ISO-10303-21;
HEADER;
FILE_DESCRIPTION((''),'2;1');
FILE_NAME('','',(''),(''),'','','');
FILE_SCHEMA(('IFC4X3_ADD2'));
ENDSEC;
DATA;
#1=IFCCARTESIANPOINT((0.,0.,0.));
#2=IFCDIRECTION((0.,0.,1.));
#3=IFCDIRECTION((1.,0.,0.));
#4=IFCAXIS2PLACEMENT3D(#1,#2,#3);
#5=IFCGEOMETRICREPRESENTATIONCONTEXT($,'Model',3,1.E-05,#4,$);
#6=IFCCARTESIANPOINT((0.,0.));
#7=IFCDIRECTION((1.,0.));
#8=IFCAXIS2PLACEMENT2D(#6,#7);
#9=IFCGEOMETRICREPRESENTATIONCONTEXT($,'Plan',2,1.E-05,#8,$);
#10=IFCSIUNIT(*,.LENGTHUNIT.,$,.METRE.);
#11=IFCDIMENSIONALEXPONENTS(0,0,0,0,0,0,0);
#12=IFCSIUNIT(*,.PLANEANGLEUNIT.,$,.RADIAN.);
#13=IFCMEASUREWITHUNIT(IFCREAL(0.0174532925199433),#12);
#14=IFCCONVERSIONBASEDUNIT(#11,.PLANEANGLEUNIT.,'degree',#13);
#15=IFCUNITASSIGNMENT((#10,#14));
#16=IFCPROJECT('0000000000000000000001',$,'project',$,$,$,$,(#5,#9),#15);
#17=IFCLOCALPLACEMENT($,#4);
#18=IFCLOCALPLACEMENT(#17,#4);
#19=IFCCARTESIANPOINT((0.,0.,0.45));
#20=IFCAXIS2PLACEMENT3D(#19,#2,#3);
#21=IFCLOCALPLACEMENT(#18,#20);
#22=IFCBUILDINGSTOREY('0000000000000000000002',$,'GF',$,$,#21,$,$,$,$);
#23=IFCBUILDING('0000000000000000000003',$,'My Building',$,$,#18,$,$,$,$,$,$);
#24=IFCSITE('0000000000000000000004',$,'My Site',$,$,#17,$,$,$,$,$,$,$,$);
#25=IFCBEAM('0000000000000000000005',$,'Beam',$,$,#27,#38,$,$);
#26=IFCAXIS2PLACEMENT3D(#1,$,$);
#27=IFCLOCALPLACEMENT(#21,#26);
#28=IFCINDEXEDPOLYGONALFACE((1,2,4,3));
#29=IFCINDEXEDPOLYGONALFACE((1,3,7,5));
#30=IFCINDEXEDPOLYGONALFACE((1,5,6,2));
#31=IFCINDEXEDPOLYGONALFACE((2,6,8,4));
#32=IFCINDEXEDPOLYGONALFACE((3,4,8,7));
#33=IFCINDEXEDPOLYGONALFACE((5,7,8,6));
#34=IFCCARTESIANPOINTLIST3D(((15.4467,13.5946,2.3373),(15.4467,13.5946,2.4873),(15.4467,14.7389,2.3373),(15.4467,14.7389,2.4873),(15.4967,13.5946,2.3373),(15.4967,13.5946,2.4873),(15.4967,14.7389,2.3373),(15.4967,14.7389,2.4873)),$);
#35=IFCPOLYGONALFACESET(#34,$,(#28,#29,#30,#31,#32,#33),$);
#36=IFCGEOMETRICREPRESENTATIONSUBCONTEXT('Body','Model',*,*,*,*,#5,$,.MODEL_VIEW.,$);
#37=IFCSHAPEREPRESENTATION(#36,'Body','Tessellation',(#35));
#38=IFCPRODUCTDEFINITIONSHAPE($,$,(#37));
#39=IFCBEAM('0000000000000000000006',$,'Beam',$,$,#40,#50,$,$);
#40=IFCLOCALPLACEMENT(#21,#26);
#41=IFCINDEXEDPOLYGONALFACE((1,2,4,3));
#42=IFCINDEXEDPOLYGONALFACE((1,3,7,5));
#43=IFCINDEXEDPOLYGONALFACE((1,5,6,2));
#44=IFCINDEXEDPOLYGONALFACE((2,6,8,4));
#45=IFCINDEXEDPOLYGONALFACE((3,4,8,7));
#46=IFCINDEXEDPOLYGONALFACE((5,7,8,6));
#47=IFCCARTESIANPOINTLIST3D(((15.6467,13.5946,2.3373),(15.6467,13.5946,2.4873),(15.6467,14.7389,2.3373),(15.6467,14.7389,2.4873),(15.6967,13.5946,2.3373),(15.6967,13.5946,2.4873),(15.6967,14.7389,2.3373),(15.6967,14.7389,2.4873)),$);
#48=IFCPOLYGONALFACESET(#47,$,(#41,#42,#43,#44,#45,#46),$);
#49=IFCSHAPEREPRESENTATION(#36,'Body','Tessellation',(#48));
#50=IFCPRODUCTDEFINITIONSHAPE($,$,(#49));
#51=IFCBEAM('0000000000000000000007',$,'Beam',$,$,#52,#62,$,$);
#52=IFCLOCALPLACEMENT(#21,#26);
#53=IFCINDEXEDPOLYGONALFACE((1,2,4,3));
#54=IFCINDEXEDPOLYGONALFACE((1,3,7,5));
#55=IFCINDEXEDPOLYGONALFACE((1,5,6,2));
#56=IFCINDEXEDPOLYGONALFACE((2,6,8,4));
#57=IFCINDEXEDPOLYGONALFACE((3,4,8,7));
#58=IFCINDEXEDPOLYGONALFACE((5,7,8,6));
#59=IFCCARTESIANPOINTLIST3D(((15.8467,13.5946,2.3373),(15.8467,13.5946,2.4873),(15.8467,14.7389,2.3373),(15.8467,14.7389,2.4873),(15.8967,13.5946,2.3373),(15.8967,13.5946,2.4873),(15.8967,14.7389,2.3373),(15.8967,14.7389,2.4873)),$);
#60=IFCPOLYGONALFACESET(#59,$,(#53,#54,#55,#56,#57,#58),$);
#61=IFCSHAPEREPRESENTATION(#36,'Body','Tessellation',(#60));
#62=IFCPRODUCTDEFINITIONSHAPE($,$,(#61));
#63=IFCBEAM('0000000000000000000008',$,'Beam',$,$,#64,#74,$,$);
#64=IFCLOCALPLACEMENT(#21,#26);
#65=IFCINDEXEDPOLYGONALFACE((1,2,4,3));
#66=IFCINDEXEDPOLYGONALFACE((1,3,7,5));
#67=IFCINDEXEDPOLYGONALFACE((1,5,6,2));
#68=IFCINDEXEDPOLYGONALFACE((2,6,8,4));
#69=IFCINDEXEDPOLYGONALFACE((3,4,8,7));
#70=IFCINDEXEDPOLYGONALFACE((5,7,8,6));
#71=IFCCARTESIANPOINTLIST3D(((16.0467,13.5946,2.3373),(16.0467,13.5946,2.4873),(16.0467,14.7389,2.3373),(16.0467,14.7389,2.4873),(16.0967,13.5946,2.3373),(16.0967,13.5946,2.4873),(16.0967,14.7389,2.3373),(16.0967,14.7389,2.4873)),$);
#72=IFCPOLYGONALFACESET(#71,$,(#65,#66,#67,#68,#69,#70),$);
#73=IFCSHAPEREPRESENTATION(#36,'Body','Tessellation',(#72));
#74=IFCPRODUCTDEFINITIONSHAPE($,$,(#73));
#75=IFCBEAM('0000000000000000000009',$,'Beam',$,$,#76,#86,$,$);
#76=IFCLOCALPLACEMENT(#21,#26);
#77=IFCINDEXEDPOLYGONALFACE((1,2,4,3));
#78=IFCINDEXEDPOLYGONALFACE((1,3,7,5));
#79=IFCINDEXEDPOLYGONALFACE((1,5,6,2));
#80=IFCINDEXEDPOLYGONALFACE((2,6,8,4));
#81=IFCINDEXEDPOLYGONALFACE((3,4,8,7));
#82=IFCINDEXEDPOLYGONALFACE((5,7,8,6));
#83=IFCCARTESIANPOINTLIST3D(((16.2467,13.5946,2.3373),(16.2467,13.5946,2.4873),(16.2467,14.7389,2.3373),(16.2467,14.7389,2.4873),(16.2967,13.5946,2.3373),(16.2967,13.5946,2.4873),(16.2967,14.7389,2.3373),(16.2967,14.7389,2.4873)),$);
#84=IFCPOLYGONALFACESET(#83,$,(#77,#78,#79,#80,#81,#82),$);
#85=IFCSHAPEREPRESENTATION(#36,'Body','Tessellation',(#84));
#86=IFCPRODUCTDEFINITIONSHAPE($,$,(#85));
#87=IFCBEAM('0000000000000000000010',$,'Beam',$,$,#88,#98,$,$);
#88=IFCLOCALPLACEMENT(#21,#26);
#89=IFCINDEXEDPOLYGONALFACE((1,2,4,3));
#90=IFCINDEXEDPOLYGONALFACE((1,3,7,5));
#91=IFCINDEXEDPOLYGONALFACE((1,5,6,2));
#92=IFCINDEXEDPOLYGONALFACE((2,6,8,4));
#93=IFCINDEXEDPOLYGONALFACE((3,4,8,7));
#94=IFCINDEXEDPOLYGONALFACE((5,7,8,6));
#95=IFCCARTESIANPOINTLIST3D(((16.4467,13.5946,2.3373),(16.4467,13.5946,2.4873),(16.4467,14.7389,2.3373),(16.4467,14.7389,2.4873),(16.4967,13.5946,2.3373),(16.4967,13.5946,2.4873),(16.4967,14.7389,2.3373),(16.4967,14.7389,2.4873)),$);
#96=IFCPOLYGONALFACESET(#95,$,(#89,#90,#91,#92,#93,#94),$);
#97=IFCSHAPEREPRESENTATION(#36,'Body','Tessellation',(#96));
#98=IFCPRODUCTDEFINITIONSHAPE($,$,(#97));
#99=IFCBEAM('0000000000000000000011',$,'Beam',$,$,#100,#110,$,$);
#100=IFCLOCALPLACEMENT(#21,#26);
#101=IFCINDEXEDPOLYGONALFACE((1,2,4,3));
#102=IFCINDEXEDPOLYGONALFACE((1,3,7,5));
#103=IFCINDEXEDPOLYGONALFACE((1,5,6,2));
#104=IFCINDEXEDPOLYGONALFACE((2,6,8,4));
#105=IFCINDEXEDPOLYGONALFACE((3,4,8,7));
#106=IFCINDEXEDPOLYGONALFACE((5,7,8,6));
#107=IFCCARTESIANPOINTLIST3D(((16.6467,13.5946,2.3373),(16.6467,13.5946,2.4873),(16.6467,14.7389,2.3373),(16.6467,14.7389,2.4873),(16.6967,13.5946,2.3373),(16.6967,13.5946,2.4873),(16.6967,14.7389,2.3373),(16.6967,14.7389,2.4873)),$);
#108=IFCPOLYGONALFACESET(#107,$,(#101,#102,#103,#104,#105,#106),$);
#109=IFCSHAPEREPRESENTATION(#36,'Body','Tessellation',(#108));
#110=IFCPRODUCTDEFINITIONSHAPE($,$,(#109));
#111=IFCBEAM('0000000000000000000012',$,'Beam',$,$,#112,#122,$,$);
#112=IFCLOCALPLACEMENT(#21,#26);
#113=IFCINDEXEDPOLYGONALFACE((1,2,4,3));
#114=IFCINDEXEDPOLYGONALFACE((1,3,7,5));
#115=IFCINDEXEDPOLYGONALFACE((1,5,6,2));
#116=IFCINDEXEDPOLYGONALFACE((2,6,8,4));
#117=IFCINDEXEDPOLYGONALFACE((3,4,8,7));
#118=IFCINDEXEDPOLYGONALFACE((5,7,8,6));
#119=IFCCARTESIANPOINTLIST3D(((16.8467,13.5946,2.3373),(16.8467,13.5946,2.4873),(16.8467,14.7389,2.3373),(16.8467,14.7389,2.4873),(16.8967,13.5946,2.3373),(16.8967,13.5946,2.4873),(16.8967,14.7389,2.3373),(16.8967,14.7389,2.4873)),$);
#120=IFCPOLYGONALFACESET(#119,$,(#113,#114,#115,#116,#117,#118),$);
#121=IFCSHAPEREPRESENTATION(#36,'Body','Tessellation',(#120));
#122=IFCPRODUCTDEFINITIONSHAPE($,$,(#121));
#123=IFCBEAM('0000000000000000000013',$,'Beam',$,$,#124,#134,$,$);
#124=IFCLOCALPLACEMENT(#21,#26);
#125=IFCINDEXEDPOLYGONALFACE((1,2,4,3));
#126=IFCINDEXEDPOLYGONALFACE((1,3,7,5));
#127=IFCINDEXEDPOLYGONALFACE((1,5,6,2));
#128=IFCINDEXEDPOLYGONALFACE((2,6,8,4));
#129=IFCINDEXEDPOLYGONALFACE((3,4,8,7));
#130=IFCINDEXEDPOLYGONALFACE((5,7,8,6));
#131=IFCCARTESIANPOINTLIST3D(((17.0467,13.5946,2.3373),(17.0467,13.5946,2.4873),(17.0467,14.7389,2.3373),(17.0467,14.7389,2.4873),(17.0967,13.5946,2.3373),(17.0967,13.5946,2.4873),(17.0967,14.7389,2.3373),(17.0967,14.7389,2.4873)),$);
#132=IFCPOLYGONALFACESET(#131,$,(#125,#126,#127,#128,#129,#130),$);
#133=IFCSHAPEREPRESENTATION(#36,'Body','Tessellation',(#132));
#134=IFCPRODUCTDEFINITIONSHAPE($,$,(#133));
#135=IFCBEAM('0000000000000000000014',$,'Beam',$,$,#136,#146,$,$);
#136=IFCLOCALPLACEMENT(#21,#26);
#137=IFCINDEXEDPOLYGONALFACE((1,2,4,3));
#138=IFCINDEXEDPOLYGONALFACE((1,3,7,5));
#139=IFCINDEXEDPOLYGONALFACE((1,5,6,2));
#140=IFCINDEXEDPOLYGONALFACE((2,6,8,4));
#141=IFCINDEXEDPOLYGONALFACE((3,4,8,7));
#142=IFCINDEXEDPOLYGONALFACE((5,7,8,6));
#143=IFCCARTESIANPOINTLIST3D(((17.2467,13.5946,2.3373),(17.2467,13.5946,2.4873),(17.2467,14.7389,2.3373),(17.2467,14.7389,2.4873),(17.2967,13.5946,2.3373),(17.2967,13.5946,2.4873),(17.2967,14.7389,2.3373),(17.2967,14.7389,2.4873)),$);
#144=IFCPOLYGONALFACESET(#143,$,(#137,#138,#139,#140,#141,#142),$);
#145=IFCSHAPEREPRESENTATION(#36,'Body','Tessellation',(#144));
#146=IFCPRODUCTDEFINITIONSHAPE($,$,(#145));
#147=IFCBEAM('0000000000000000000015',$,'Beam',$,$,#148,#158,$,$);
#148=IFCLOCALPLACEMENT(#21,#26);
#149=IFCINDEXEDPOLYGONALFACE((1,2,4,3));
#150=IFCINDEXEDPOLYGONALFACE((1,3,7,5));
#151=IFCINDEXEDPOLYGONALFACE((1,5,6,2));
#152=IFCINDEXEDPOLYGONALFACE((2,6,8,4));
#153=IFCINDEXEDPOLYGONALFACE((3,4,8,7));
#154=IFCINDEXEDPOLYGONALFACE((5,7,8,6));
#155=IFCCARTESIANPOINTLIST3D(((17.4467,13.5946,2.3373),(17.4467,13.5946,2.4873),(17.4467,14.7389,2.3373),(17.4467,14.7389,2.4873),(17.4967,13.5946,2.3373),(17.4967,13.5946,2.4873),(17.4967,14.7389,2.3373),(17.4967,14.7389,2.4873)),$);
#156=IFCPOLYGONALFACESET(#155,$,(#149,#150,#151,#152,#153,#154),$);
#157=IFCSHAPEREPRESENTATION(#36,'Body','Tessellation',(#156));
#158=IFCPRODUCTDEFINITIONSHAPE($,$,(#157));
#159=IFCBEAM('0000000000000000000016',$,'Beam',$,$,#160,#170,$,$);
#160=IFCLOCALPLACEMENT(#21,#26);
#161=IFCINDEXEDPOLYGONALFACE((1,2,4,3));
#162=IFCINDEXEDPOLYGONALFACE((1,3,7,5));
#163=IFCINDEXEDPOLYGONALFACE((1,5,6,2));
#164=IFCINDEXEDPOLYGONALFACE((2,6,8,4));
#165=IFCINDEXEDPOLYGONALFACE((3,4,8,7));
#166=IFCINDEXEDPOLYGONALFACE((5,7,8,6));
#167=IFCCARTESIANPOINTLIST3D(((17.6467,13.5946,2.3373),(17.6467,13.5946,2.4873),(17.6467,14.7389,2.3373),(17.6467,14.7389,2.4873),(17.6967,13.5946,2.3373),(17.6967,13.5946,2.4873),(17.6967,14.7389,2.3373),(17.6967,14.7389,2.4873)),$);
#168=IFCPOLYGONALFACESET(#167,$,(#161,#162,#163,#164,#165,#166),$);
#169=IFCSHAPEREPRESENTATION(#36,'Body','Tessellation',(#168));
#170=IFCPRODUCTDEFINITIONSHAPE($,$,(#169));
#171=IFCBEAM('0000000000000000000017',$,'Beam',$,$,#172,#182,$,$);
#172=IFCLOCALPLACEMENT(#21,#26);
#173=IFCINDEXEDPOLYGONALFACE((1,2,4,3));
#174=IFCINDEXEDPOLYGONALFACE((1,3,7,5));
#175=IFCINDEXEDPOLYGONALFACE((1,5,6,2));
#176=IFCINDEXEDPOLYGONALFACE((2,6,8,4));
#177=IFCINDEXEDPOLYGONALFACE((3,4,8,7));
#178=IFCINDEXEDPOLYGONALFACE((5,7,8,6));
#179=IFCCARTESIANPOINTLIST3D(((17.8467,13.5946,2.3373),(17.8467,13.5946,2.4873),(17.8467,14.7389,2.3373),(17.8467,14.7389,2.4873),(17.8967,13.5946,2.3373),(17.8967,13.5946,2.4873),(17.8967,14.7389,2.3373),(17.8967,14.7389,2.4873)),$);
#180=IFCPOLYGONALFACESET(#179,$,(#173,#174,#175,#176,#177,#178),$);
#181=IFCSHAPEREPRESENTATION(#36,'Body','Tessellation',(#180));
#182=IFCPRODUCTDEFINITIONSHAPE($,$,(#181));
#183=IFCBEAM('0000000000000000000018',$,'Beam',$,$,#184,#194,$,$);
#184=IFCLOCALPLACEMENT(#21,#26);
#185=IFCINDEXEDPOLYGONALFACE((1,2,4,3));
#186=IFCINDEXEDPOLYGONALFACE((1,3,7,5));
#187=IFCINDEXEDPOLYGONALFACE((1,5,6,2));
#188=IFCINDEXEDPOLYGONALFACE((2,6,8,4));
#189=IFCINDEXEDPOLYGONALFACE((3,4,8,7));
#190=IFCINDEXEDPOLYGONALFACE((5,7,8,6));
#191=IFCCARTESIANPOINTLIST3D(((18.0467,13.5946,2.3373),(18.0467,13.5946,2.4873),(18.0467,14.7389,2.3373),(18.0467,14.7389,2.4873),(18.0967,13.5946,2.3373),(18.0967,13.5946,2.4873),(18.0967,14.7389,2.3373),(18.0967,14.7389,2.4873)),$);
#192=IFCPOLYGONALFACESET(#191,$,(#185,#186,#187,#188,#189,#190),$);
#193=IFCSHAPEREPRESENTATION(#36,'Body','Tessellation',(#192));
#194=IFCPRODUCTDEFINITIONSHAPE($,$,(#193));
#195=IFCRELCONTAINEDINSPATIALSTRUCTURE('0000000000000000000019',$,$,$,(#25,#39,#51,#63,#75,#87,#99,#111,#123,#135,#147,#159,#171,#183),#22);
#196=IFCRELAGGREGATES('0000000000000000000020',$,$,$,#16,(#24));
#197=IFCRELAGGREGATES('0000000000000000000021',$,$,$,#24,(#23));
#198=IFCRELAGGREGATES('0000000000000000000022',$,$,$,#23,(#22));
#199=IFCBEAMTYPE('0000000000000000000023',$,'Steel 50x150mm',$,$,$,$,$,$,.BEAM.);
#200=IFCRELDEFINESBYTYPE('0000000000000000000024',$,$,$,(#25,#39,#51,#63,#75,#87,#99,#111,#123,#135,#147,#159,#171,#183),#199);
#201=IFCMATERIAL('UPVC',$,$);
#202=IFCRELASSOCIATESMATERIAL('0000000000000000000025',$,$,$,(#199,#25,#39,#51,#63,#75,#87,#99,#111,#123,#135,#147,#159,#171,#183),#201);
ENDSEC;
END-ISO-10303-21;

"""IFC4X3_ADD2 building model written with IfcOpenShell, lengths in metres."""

from ifc_helpers import new_model, entity, si_unit, converted_unit, frame, origin_with_axes, origin_2d_with_axis, place, context, subcontext, project, spatial, rectangle, extrude, material, material_profile, profile_set, profile_usage, type_object, element, save


model = new_model("IFC4X3_ADD2")

# Units and contexts
model_context = context("Model", 3, precision=1e-05, world=origin_with_axes())
plan_context = context("Plan", 2, precision=1e-05, world=origin_2d_with_axis())
body_context = subcontext(model_context, "Body", "Model", "MODEL_VIEW")
ifc_project = project(units=[si_unit("LENGTHUNIT", "METRE"), converted_unit("PLANEANGLEUNIT", "degree", entity("IfcReal", 0.0174532925199433), si_unit("PLANEANGLEUNIT", "RADIAN"), dimensions=[0, 0, 0, 0, 0, 0, 0])], contexts=[model_context, plan_context])

# Site, building, storey
site_placement = place(None, origin_with_axes())
site = spatial("IfcSite", under=ifc_project, at=site_placement, Name="My Site")
building_placement = place(site_placement, origin_with_axes())
building = spatial("IfcBuilding", under=site, at=building_placement, Name="My Building")
storey_placement = place(building_placement, frame((0.0, 0.0, 0.45), z_axis=(0.0, 0.0, 1.0), x_axis=(1.0, 0.0, 0.0)))
storey = spatial("IfcBuildingStorey", under=building, at=storey_placement, Name="GF")

# Beams
ifc_material = material(Name="UPVC")
ifc_material_profile = material_profile(ifc_material, rectangle(XDim=0.05, YDim=0.15))
ifc_profile_set = profile_set([ifc_material_profile])
ifc_profile_usage_1 = profile_usage(ifc_profile_set)
beam_type = type_object("IfcBeamType", Name="Steel 50x150mm", PredefinedType="BEAM", material=ifc_profile_set)
beam_1_placement = place(storey_placement, frame((15.4717, 14.7389, 2.4123), z_axis=(0.0, -1.0, 0.0), x_axis=(1.0, 0.0, 0.0)))
element("IfcBeam", 1, at=beam_1_placement, inside=storey, type_object=beam_type, material=ifc_profile_usage_1, Name="Beam", context=body_context, shape_type="SweptSolid", body=[
    extrude(rectangle(XDim=0.05, YDim=0.15), origin_with_axes(), (0.0, 0.0, 1.0), 1.1444),
])
ifc_profile_usage_2 = profile_usage(ifc_profile_set)
beam_2_placement = place(storey_placement, frame((15.6717, 14.7389, 2.4123), z_axis=(0.0, -1.0, 0.0), x_axis=(1.0, 0.0, 0.0)))
element("IfcBeam", 2, at=beam_2_placement, inside=storey, type_object=beam_type, material=ifc_profile_usage_2, Name="Beam", context=body_context, shape_type="SweptSolid", body=[
    extrude(rectangle(XDim=0.05, YDim=0.15), origin_with_axes(), (0.0, 0.0, 1.0), 1.1444),
])
ifc_profile_usage_3 = profile_usage(ifc_profile_set)
beam_3_placement = place(storey_placement, frame((15.8717, 14.7389, 2.4123), z_axis=(0.0, -1.0, 0.0), x_axis=(1.0, 0.0, 0.0)))
element("IfcBeam", 3, at=beam_3_placement, inside=storey, type_object=beam_type, material=ifc_profile_usage_3, Name="Beam", context=body_context, shape_type="SweptSolid", body=[
    extrude(rectangle(XDim=0.05, YDim=0.15), origin_with_axes(), (0.0, 0.0, 1.0), 1.1444),
])
ifc_profile_usage_4 = profile_usage(ifc_profile_set)
beam_4_placement = place(storey_placement, frame((16.0717, 14.7389, 2.4123), z_axis=(0.0, -1.0, 0.0), x_axis=(1.0, 0.0, 0.0)))
element("IfcBeam", 4, at=beam_4_placement, inside=storey, type_object=beam_type, material=ifc_profile_usage_4, Name="Beam", context=body_context, shape_type="SweptSolid", body=[
    extrude(rectangle(XDim=0.05, YDim=0.15), origin_with_axes(), (0.0, 0.0, 1.0), 1.1444),
])
ifc_profile_usage_5 = profile_usage(ifc_profile_set)
beam_5_placement = place(storey_placement, frame((16.2717, 14.7389, 2.4123), z_axis=(0.0, -1.0, 0.0), x_axis=(1.0, 0.0, 0.0)))
element("IfcBeam", 5, at=beam_5_placement, inside=storey, type_object=beam_type, material=ifc_profile_usage_5, Name="Beam", context=body_context, shape_type="SweptSolid", body=[
    extrude(rectangle(XDim=0.05, YDim=0.15), origin_with_axes(), (0.0, 0.0, 1.0), 1.1444),
])
ifc_profile_usage_6 = profile_usage(ifc_profile_set)
beam_6_placement = place(storey_placement, frame((16.4717, 14.7389, 2.4123), z_axis=(0.0, -1.0, 0.0), x_axis=(1.0, 0.0, 0.0)))
element("IfcBeam", 6, at=beam_6_placement, inside=storey, type_object=beam_type, material=ifc_profile_usage_6, Name="Beam", context=body_context, shape_type="SweptSolid", body=[
    extrude(rectangle(XDim=0.05, YDim=0.15), origin_with_axes(), (0.0, 0.0, 1.0), 1.1444),
])
ifc_profile_usage_7 = profile_usage(ifc_profile_set)
beam_7_placement = place(storey_placement, frame((16.6717, 14.7389, 2.4123), z_axis=(0.0, -1.0, 0.0), x_axis=(1.0, 0.0, 0.0)))
element("IfcBeam", 7, at=beam_7_placement, inside=storey, type_object=beam_type, material=ifc_profile_usage_7, Name="Beam", context=body_context, shape_type="SweptSolid", body=[
    extrude(rectangle(XDim=0.05, YDim=0.15), origin_with_axes(), (0.0, 0.0, 1.0), 1.1444),
])
ifc_profile_usage_8 = profile_usage(ifc_profile_set)
beam_8_placement = place(storey_placement, frame((16.8717, 14.7389, 2.4123), z_axis=(0.0, -1.0, 0.0), x_axis=(1.0, 0.0, 0.0)))
element("IfcBeam", 8, at=beam_8_placement, inside=storey, type_object=beam_type, material=ifc_profile_usage_8, Name="Beam", context=body_context, shape_type="SweptSolid", body=[
    extrude(rectangle(XDim=0.05, YDim=0.15), origin_with_axes(), (0.0, 0.0, 1.0), 1.1444),
])
ifc_profile_usage_9 = profile_usage(ifc_profile_set)
beam_9_placement = place(storey_placement, frame((17.0717, 14.7389, 2.4123), z_axis=(0.0, -1.0, 0.0), x_axis=(1.0, 0.0, 0.0)))
element("IfcBeam", 9, at=beam_9_placement, inside=storey, type_object=beam_type, material=ifc_profile_usage_9, Name="Beam", context=body_context, shape_type="SweptSolid", body=[
    extrude(rectangle(XDim=0.05, YDim=0.15), origin_with_axes(), (0.0, 0.0, 1.0), 1.1444),
])
ifc_profile_usage_10 = profile_usage(ifc_profile_set)
beam_10_placement = place(storey_placement, frame((17.2717, 14.7389, 2.4123), z_axis=(0.0, -1.0, 0.0), x_axis=(1.0, 0.0, 0.0)))
element("IfcBeam", 10, at=beam_10_placement, inside=storey, type_object=beam_type, material=ifc_profile_usage_10, Name="Beam", context=body_context, shape_type="SweptSolid", body=[
    extrude(rectangle(XDim=0.05, YDim=0.15), origin_with_axes(), (0.0, 0.0, 1.0), 1.1444),
])
ifc_profile_usage_11 = profile_usage(ifc_profile_set)
beam_11_placement = place(storey_placement, frame((17.4717, 14.7389, 2.4123), z_axis=(0.0, -1.0, 0.0), x_axis=(1.0, 0.0, 0.0)))
element("IfcBeam", 11, at=beam_11_placement, inside=storey, type_object=beam_type, material=ifc_profile_usage_11, Name="Beam", context=body_context, shape_type="SweptSolid", body=[
    extrude(rectangle(XDim=0.05, YDim=0.15), origin_with_axes(), (0.0, 0.0, 1.0), 1.1444),
])
ifc_profile_usage_12 = profile_usage(ifc_profile_set)
beam_12_placement = place(storey_placement, frame((17.6717, 14.7389, 2.4123), z_axis=(0.0, -1.0, 0.0), x_axis=(1.0, 0.0, 0.0)))
element("IfcBeam", 12, at=beam_12_placement, inside=storey, type_object=beam_type, material=ifc_profile_usage_12, Name="Beam", context=body_context, shape_type="SweptSolid", body=[
    extrude(rectangle(XDim=0.05, YDim=0.15), origin_with_axes(), (0.0, 0.0, 1.0), 1.1444),
])
ifc_profile_usage_13 = profile_usage(ifc_profile_set)
beam_13_placement = place(storey_placement, frame((17.8717, 14.7389, 2.4123), z_axis=(0.0, -1.0, 0.0), x_axis=(1.0, 0.0, 0.0)))
element("IfcBeam", 13, at=beam_13_placement, inside=storey, type_object=beam_type, material=ifc_profile_usage_13, Name="Beam", context=body_context, shape_type="SweptSolid", body=[
    extrude(rectangle(XDim=0.05, YDim=0.15), origin_with_axes(), (0.0, 0.0, 1.0), 1.1444),
])
ifc_profile_usage_14 = profile_usage(ifc_profile_set)
beam_14_placement = place(storey_placement, frame((18.0717, 14.7389, 2.4123), z_axis=(0.0, -1.0, 0.0), x_axis=(1.0, 0.0, 0.0)))
element("IfcBeam", 14, at=beam_14_placement, inside=storey, type_object=beam_type, material=ifc_profile_usage_14, Name="Beam", context=body_context, shape_type="SweptSolid", body=[
    extrude(rectangle(XDim=0.05, YDim=0.15), origin_with_axes(), (0.0, 0.0, 1.0), 1.1444),
])

save(model, "model.ifc")
